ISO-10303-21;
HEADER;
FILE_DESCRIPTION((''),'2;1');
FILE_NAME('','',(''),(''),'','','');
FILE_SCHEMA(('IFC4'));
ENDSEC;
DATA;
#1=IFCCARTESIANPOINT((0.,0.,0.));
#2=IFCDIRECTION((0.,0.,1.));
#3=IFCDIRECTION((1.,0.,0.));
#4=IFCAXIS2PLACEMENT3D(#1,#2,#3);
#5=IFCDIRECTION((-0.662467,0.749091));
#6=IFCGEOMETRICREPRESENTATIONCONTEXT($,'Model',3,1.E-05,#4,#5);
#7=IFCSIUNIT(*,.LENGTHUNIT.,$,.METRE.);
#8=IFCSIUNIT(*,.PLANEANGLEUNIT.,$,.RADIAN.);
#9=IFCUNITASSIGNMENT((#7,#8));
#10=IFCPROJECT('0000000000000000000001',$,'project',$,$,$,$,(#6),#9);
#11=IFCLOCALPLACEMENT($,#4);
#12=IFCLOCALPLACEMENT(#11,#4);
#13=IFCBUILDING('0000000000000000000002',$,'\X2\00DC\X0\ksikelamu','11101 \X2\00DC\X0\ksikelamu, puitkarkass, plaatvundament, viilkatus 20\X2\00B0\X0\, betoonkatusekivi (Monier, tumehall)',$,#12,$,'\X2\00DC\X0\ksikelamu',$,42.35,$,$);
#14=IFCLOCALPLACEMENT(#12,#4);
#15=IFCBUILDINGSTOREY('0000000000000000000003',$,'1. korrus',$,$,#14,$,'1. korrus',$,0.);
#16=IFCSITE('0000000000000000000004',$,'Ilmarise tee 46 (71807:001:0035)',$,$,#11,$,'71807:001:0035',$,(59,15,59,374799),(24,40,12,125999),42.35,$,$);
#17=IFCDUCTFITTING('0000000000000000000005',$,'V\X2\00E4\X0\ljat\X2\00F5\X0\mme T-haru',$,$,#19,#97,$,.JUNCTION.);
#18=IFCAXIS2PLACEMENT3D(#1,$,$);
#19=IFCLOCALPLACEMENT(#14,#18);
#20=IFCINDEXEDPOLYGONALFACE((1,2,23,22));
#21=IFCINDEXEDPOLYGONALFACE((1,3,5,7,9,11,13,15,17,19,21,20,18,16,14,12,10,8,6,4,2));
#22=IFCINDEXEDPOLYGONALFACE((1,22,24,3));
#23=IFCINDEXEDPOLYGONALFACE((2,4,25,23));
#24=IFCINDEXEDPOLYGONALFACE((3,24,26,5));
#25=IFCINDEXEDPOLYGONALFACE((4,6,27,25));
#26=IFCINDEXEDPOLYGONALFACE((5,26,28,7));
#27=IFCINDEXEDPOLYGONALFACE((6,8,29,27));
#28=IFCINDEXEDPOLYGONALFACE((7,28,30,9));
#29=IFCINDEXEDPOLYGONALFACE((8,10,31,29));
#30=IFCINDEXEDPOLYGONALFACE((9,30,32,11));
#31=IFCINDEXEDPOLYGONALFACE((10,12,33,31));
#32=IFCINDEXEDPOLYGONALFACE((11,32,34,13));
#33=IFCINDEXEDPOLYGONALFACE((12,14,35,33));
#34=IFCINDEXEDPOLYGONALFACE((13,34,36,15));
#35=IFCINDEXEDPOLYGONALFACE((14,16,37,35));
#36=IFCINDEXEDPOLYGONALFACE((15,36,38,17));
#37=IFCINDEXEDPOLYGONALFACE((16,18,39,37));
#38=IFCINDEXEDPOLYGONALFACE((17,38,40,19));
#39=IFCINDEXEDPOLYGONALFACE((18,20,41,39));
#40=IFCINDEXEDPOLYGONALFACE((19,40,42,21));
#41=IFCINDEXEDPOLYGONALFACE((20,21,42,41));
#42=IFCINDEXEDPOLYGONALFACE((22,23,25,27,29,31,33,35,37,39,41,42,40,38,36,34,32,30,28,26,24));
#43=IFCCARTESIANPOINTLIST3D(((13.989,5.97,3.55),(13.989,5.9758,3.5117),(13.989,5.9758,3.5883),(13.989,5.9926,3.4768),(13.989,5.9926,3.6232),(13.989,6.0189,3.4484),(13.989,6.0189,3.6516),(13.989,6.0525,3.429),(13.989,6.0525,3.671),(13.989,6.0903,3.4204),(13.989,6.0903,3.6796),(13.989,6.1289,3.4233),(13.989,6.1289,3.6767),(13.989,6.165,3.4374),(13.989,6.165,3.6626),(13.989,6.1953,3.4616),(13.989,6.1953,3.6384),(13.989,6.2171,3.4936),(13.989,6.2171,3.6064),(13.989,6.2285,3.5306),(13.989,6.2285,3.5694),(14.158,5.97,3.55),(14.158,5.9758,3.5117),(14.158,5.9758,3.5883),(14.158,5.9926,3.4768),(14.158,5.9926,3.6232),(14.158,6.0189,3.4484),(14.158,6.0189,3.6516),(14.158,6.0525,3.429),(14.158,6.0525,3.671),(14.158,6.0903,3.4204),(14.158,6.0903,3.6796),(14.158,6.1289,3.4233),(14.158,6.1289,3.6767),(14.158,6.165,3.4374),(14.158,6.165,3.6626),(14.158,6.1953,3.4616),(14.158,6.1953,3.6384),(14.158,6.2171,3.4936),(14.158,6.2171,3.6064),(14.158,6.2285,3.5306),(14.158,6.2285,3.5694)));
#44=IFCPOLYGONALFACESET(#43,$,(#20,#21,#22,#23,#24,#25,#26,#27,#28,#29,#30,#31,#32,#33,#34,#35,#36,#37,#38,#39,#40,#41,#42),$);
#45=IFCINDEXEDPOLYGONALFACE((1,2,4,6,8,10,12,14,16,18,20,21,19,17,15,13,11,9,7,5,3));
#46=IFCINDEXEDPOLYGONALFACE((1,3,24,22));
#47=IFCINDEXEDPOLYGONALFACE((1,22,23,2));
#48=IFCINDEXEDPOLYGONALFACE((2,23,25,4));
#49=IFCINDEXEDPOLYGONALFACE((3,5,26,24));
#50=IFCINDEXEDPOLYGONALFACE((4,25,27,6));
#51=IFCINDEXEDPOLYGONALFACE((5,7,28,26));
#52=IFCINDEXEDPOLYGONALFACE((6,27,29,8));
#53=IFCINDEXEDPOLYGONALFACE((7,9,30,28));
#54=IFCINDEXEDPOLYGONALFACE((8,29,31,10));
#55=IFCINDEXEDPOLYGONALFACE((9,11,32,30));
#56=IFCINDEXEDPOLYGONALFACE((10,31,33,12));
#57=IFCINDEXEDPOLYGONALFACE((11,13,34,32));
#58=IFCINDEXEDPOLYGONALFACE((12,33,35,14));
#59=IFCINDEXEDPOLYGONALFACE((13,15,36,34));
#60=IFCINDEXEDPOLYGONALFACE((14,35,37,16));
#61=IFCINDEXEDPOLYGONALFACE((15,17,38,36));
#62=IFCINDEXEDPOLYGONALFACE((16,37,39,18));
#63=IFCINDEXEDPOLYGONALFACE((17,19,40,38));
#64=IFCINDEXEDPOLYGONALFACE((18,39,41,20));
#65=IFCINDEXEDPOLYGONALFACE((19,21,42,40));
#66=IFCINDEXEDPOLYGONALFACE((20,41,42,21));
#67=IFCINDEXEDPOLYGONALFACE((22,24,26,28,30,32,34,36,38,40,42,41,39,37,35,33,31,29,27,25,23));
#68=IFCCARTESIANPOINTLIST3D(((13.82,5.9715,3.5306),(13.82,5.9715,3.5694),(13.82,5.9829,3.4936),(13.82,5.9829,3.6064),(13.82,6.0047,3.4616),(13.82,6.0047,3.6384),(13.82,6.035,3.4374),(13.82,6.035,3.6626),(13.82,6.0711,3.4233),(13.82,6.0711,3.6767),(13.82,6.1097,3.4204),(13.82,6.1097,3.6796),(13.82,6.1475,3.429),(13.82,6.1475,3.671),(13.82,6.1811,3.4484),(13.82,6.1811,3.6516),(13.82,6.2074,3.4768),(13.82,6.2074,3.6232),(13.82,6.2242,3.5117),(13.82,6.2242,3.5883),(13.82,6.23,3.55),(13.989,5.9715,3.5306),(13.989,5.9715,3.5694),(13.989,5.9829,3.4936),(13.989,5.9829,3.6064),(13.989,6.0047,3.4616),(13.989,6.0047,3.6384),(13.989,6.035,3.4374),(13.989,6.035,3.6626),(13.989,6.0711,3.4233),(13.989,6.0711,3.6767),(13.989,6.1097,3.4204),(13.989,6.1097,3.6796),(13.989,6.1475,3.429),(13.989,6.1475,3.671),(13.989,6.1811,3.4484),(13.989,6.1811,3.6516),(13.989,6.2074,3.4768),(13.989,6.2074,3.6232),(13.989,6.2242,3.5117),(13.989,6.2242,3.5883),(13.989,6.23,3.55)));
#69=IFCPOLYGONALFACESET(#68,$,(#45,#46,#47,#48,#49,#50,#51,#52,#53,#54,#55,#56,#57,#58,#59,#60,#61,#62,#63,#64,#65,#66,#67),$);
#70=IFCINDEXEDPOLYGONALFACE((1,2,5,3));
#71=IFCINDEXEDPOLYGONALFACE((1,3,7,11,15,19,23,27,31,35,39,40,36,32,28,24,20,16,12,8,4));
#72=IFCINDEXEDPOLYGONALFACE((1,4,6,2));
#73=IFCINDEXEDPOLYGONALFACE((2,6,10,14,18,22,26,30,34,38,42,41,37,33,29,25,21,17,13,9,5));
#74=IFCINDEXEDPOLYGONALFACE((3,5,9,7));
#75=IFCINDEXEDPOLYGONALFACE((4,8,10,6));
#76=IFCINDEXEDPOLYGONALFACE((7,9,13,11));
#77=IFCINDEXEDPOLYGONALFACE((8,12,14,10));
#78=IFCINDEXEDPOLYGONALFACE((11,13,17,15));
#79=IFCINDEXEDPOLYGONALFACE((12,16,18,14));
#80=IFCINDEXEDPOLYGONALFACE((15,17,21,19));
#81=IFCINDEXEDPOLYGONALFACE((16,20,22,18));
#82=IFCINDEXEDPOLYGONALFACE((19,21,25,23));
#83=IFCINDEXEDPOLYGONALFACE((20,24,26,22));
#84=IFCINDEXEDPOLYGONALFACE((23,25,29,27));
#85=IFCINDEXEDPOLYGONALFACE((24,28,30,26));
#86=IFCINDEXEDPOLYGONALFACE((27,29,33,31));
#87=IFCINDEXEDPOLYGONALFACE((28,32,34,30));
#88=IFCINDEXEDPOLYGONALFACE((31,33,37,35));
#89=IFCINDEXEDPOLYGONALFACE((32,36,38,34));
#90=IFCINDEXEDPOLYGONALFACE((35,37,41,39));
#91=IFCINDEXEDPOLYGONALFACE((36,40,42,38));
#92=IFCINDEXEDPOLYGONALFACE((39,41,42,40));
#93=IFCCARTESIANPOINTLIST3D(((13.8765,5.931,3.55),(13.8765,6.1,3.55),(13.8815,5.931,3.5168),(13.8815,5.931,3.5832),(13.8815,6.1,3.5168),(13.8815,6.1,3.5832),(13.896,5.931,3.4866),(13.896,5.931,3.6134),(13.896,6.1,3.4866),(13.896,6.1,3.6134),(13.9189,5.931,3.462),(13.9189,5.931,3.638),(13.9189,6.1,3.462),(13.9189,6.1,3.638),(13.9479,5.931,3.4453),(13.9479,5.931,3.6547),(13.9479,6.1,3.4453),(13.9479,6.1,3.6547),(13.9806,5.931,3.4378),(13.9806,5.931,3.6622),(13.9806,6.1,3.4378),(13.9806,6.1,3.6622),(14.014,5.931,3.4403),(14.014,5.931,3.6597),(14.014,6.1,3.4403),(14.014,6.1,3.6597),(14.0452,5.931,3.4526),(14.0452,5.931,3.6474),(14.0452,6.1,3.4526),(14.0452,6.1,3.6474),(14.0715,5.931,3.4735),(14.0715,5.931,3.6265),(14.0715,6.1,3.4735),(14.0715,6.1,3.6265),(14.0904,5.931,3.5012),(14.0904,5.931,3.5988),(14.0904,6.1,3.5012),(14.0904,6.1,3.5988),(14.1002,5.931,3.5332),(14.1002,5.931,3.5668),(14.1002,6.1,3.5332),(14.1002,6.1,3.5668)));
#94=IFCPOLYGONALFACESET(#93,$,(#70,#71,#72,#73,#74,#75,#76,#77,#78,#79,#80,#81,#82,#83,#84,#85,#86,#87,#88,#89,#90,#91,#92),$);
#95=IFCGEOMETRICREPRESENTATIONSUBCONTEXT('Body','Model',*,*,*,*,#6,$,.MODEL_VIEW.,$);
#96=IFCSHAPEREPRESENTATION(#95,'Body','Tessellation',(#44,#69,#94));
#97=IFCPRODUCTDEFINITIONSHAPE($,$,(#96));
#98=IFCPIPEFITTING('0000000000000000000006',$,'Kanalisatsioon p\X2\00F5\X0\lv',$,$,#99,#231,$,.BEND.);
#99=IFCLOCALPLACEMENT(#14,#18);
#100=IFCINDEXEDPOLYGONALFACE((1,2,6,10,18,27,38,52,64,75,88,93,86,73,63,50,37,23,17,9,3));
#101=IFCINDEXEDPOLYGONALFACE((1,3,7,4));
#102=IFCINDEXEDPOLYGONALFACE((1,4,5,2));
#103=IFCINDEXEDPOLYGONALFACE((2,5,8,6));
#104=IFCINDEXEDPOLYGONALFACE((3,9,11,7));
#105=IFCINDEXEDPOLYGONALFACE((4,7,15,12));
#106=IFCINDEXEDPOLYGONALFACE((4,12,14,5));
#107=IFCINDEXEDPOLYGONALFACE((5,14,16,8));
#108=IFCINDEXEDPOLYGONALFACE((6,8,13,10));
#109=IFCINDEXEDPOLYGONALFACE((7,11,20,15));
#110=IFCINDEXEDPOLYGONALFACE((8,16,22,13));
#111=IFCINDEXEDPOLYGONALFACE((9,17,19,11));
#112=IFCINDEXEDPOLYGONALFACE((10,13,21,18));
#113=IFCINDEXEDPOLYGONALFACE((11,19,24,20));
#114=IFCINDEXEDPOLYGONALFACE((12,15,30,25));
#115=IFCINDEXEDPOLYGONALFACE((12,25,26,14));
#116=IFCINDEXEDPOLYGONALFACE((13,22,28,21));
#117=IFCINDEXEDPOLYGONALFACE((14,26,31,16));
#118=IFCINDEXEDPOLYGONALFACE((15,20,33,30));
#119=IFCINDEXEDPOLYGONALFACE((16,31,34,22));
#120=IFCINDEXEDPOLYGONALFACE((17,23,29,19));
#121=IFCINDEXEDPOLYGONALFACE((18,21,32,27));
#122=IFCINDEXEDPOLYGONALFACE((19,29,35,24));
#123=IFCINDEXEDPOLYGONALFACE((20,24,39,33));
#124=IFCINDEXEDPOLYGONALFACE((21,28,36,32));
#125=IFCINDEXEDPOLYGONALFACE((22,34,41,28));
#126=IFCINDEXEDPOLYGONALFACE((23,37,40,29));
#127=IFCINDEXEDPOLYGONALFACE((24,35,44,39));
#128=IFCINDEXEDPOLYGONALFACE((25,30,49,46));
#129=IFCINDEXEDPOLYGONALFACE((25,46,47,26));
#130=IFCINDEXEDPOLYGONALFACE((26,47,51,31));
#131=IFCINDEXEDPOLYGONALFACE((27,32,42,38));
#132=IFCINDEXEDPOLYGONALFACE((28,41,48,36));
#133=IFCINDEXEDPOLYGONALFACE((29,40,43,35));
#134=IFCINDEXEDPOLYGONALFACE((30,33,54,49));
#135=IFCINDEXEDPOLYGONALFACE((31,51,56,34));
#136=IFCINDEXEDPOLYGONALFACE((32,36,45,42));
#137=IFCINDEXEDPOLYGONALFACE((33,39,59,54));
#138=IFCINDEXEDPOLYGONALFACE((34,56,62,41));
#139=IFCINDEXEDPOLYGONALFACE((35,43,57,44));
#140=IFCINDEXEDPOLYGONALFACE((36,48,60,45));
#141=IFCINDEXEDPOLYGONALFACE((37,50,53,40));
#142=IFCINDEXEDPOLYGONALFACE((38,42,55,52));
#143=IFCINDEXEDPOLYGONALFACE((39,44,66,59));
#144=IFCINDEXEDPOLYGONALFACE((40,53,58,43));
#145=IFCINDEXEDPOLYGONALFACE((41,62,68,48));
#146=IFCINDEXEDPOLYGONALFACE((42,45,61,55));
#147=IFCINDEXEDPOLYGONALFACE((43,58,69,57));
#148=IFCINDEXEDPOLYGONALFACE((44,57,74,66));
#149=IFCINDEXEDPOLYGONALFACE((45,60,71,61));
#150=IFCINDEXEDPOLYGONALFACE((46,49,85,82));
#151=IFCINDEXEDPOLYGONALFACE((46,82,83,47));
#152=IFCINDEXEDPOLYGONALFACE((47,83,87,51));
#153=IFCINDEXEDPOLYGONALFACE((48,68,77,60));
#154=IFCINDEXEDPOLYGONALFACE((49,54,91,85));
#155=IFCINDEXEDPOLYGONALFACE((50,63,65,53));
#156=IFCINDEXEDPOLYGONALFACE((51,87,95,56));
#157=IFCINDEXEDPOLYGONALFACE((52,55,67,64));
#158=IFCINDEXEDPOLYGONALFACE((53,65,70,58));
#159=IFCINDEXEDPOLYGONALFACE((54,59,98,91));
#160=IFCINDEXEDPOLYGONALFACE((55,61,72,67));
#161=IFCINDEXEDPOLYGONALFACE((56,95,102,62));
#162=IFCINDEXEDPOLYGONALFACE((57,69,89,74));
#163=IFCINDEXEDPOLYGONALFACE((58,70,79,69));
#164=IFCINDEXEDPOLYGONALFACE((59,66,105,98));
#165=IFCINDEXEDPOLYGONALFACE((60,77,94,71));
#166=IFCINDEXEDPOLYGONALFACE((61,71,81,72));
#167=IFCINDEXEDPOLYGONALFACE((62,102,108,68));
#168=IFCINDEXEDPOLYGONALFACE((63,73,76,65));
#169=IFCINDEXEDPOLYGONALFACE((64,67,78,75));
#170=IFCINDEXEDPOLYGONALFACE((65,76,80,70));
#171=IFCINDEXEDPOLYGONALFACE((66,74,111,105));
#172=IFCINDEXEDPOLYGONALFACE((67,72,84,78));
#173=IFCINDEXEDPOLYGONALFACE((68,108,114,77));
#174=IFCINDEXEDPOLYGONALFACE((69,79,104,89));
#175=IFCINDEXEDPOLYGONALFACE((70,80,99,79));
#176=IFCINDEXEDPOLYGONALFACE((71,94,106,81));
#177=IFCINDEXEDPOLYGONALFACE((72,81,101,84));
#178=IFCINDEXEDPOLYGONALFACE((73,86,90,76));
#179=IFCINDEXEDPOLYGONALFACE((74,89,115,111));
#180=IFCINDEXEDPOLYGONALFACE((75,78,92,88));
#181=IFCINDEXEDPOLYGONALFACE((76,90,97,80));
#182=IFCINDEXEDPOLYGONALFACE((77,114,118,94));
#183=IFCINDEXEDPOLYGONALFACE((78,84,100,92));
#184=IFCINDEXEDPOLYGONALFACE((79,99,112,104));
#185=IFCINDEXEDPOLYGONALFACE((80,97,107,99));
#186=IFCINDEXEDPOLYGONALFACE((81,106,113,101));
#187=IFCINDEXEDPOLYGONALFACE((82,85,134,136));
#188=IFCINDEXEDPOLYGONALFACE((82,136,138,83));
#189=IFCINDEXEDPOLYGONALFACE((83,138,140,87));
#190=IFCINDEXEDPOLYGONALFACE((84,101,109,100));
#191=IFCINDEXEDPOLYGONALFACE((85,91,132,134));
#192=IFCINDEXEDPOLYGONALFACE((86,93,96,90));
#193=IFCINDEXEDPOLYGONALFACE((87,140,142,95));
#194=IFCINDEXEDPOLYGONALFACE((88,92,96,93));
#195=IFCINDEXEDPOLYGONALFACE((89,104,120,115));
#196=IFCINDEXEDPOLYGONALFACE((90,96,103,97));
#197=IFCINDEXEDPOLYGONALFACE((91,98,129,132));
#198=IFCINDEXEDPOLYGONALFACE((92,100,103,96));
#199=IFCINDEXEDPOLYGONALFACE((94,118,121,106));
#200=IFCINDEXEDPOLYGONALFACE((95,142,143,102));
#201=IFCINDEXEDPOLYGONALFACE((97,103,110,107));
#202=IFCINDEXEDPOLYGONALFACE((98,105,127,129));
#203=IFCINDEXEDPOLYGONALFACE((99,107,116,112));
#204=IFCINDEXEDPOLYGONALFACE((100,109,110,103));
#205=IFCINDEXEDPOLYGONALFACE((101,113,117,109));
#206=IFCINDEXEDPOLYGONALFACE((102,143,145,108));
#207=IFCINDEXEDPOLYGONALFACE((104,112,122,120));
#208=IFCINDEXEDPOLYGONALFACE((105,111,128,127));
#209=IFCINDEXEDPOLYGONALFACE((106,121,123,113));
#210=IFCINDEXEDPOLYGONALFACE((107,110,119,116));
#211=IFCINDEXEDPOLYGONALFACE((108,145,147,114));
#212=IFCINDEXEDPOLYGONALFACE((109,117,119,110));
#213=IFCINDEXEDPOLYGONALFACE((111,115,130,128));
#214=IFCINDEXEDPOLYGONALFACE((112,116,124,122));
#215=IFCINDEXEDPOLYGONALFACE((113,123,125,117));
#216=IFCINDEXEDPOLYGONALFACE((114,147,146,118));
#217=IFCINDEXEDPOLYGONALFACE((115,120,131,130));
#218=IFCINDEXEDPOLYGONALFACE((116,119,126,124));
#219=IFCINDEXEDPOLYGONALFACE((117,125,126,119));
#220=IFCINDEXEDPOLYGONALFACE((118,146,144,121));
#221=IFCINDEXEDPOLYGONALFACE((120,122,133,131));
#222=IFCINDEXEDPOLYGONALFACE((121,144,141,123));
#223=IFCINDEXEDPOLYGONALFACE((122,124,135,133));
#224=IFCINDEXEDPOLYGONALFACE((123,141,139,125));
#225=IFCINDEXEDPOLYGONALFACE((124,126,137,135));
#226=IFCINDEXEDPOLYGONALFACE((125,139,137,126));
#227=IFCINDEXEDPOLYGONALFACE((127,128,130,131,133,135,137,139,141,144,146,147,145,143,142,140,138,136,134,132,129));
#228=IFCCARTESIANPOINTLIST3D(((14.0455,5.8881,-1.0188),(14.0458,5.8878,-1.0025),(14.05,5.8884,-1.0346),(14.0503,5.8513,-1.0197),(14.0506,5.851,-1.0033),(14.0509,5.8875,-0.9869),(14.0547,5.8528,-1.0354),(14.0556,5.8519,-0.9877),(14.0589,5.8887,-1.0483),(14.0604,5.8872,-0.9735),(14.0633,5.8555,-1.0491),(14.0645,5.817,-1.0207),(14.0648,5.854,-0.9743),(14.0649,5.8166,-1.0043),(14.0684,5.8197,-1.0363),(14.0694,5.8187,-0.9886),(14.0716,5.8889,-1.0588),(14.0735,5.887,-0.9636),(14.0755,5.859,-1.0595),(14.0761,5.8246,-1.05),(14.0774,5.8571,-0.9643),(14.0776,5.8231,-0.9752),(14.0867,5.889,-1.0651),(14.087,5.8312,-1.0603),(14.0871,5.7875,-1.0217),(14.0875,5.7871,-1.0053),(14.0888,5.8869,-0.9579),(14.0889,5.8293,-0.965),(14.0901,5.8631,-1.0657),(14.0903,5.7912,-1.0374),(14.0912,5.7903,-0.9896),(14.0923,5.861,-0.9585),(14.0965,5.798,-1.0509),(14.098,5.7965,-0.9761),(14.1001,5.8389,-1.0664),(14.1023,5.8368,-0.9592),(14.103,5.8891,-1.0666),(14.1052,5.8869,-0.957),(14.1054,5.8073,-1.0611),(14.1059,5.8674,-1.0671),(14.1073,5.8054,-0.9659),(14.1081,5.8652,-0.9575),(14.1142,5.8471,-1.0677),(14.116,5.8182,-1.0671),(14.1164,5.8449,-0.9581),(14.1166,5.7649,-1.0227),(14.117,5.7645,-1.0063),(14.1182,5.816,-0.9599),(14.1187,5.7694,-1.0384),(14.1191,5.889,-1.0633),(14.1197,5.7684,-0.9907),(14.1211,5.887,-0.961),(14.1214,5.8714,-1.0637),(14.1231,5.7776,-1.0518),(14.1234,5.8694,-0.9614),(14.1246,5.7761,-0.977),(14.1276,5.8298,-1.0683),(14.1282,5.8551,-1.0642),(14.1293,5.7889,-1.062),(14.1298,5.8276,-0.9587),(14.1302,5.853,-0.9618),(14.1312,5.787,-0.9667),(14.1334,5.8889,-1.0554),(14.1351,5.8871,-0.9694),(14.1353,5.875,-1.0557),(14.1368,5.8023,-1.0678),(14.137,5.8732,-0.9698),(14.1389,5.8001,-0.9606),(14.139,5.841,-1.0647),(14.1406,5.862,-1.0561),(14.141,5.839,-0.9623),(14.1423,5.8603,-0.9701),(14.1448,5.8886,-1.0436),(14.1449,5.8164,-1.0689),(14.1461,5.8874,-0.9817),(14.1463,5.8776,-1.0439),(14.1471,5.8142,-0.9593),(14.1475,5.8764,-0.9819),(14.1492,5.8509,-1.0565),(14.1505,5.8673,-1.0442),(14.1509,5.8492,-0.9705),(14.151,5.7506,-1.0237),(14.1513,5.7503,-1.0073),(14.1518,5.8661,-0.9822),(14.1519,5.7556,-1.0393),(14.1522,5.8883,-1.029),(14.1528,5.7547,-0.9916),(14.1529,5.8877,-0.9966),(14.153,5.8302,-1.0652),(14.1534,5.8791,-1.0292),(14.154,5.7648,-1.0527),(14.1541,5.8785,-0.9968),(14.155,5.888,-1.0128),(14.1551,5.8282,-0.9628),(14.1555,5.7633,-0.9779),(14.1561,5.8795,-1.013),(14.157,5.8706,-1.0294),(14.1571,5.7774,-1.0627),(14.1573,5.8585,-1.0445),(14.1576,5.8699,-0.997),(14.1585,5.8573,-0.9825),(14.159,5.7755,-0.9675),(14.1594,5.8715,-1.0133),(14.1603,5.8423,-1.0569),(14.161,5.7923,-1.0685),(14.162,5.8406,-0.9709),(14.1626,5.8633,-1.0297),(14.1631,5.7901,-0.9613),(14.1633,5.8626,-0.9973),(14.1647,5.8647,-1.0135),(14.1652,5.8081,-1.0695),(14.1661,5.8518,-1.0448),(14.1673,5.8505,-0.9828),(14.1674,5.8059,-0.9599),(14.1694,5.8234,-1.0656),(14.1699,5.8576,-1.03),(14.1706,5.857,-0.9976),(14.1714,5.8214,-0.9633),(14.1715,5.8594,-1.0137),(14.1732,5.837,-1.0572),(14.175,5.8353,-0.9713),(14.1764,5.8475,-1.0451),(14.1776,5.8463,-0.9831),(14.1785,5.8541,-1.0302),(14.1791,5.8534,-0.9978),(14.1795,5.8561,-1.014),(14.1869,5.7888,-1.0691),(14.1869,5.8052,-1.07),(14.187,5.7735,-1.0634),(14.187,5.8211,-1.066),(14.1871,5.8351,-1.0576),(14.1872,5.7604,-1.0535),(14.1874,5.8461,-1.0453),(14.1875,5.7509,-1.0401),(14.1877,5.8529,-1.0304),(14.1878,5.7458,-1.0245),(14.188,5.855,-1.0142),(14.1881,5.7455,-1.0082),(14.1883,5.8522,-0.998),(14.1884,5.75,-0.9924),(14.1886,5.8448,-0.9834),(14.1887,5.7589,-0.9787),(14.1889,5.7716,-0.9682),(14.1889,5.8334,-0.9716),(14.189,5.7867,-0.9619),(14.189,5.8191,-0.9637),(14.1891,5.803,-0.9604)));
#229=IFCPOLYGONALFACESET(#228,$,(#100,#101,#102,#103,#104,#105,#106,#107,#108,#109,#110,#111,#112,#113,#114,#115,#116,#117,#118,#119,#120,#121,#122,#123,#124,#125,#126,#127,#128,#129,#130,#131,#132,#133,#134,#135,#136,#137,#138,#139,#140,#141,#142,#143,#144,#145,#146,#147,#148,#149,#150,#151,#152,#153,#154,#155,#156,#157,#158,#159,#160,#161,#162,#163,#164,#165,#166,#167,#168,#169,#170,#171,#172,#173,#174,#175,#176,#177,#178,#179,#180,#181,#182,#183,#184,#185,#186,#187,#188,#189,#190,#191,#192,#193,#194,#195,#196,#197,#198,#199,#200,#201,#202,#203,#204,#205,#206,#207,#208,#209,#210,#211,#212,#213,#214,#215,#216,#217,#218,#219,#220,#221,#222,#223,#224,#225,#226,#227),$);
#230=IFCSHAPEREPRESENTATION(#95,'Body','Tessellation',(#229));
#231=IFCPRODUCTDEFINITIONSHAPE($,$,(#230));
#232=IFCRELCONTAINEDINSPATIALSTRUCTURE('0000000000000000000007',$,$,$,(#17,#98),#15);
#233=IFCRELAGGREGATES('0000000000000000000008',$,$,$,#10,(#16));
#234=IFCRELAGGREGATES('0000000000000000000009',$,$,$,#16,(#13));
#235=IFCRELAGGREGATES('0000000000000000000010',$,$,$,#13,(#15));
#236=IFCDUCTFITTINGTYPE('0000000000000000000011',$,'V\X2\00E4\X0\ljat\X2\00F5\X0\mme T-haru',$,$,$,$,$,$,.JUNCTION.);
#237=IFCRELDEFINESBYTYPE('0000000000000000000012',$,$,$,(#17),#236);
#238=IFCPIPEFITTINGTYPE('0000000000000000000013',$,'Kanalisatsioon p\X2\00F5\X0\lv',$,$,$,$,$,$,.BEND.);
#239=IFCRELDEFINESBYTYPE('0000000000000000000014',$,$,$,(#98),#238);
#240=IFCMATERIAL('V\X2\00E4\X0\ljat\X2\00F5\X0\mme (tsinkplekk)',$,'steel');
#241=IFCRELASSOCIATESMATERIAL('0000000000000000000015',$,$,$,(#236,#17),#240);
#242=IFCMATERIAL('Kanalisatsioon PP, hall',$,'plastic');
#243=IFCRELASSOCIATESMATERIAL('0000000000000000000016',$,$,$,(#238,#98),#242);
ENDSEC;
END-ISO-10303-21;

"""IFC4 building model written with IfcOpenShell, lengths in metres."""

from ifc_helpers import new_model, entity, si_unit, direction, frame, origin_with_axes, place, context, subcontext, project, spatial, circle, extrude, material, type_object, element, save


model = new_model("IFC4")

# Units and contexts
model_context = context("Model", 3, precision=1e-05, world=origin_with_axes(), true_north=direction((-0.662467, 0.749091)))
body_context = subcontext(model_context, "Body", "Model", "MODEL_VIEW")
ifc_project = project(units=[si_unit("LENGTHUNIT", "METRE"), si_unit("PLANEANGLEUNIT", "RADIAN")], contexts=[model_context])

# Site, building, storey
site_placement = place(None, origin_with_axes())
site = spatial("IfcSite", under=ifc_project, at=site_placement, Name="Ilmarise tee 46 (71807:001:0035)", LongName="71807:001:0035", RefLatitude=(59, 15, 59, 374799), RefLongitude=(24, 40, 12, 125999), RefElevation=42.35)
building_placement = place(site_placement, origin_with_axes())
building = spatial("IfcBuilding", under=site, at=building_placement, Name="Üksikelamu", Description="11101 Üksikelamu, puitkarkass, plaatvundament, viilkatus 20°, betoonkatusekivi (Monier, tumehall)", LongName="Üksikelamu", ElevationOfRefHeight=42.35)
storey_placement = place(building_placement, origin_with_axes())
storey = spatial("IfcBuildingStorey", under=building, at=storey_placement, Name="1. korrus", LongName="1. korrus", Elevation=0.0)

# Duct fitting
ifc_material_1 = material(Name="Väljatõmme (tsinkplekk)", Category="steel")
duct_fitting_type_1 = type_object("IfcDuctFittingType", Name="Väljatõmme T-haru", PredefinedType="JUNCTION", material=ifc_material_1)
duct_fitting_1_placement = place(storey_placement, frame((13.989, 6.1, 3.55), z_axis=(0.0, 0.0, 1.0), x_axis=(1.0, 0.0, 0.0)))
element("IfcDuctFitting", 1, at=duct_fitting_1_placement, inside=storey, type_object=duct_fitting_type_1, material=ifc_material_1, Name="Väljatõmme T-haru", PredefinedType="JUNCTION", context=body_context, shape_type="SweptSolid", body=[
    extrude(circle(Radius=0.13), frame((0.0, 0.0, 0.0), z_axis=(1.0, 0.0, 0.0), x_axis=(0.0, -1.0, 0.0)), (0.0, 0.0, 1.0), 0.169),
    extrude(circle(Radius=0.13), frame((0.0, 0.0, 0.0), z_axis=(-1.0, 0.0, 0.0), x_axis=(0.0, 1.0, 0.0)), (0.0, 0.0, 1.0), 0.169),
    extrude(circle(Radius=0.1125), frame((0.0, 0.0, 0.0), z_axis=(0.0, -1.0, 0.0), x_axis=(-1.0, 0.0, 0.0)), (0.0, 0.0, 1.0), 0.169),
])

# Pipe fitting
ifc_material_2 = material(Name="Kanalisatsioon PP, hall", Category="plastic")
pipe_fitting_type_1 = type_object("IfcPipeFittingType", Name="Kanalisatsioon põlv", PredefinedType="BEND", material=ifc_material_2)
pipe_fitting_1_placement = place(storey_placement, frame((14.1, 5.8, -1.0135), z_axis=(0.0, 0.0, 1.0), x_axis=(1.0, 0.0, 0.0)))
element("IfcPipeFitting", 2, at=pipe_fitting_1_placement, inside=storey, type_object=pipe_fitting_type_1, material=ifc_material_2, Name="Kanalisatsioon põlv", PredefinedType="BEND", context=body_context, shape_type="SweptSolid", body=[
    entity("IfcRevolvedAreaSolid", entity("IfcCircleProfileDef", "AREA", None, None, 0.055), entity("IfcAxis2Placement3D", entity("IfcCartesianPoint", [0.0, 0.088, 0.0018]), entity("IfcDirection", [0.0, -0.9998, -0.019996]), entity("IfcDirection", [0.9998, 0.0004, -0.019988])), entity("IfcAxis1Placement", entity("IfcCartesianPoint", [0.088, 0.0, 0.0]), entity("IfcDirection", [0.0, 1.0, 0.0])), 1.570396),
])

save(model, "model.ifc")
